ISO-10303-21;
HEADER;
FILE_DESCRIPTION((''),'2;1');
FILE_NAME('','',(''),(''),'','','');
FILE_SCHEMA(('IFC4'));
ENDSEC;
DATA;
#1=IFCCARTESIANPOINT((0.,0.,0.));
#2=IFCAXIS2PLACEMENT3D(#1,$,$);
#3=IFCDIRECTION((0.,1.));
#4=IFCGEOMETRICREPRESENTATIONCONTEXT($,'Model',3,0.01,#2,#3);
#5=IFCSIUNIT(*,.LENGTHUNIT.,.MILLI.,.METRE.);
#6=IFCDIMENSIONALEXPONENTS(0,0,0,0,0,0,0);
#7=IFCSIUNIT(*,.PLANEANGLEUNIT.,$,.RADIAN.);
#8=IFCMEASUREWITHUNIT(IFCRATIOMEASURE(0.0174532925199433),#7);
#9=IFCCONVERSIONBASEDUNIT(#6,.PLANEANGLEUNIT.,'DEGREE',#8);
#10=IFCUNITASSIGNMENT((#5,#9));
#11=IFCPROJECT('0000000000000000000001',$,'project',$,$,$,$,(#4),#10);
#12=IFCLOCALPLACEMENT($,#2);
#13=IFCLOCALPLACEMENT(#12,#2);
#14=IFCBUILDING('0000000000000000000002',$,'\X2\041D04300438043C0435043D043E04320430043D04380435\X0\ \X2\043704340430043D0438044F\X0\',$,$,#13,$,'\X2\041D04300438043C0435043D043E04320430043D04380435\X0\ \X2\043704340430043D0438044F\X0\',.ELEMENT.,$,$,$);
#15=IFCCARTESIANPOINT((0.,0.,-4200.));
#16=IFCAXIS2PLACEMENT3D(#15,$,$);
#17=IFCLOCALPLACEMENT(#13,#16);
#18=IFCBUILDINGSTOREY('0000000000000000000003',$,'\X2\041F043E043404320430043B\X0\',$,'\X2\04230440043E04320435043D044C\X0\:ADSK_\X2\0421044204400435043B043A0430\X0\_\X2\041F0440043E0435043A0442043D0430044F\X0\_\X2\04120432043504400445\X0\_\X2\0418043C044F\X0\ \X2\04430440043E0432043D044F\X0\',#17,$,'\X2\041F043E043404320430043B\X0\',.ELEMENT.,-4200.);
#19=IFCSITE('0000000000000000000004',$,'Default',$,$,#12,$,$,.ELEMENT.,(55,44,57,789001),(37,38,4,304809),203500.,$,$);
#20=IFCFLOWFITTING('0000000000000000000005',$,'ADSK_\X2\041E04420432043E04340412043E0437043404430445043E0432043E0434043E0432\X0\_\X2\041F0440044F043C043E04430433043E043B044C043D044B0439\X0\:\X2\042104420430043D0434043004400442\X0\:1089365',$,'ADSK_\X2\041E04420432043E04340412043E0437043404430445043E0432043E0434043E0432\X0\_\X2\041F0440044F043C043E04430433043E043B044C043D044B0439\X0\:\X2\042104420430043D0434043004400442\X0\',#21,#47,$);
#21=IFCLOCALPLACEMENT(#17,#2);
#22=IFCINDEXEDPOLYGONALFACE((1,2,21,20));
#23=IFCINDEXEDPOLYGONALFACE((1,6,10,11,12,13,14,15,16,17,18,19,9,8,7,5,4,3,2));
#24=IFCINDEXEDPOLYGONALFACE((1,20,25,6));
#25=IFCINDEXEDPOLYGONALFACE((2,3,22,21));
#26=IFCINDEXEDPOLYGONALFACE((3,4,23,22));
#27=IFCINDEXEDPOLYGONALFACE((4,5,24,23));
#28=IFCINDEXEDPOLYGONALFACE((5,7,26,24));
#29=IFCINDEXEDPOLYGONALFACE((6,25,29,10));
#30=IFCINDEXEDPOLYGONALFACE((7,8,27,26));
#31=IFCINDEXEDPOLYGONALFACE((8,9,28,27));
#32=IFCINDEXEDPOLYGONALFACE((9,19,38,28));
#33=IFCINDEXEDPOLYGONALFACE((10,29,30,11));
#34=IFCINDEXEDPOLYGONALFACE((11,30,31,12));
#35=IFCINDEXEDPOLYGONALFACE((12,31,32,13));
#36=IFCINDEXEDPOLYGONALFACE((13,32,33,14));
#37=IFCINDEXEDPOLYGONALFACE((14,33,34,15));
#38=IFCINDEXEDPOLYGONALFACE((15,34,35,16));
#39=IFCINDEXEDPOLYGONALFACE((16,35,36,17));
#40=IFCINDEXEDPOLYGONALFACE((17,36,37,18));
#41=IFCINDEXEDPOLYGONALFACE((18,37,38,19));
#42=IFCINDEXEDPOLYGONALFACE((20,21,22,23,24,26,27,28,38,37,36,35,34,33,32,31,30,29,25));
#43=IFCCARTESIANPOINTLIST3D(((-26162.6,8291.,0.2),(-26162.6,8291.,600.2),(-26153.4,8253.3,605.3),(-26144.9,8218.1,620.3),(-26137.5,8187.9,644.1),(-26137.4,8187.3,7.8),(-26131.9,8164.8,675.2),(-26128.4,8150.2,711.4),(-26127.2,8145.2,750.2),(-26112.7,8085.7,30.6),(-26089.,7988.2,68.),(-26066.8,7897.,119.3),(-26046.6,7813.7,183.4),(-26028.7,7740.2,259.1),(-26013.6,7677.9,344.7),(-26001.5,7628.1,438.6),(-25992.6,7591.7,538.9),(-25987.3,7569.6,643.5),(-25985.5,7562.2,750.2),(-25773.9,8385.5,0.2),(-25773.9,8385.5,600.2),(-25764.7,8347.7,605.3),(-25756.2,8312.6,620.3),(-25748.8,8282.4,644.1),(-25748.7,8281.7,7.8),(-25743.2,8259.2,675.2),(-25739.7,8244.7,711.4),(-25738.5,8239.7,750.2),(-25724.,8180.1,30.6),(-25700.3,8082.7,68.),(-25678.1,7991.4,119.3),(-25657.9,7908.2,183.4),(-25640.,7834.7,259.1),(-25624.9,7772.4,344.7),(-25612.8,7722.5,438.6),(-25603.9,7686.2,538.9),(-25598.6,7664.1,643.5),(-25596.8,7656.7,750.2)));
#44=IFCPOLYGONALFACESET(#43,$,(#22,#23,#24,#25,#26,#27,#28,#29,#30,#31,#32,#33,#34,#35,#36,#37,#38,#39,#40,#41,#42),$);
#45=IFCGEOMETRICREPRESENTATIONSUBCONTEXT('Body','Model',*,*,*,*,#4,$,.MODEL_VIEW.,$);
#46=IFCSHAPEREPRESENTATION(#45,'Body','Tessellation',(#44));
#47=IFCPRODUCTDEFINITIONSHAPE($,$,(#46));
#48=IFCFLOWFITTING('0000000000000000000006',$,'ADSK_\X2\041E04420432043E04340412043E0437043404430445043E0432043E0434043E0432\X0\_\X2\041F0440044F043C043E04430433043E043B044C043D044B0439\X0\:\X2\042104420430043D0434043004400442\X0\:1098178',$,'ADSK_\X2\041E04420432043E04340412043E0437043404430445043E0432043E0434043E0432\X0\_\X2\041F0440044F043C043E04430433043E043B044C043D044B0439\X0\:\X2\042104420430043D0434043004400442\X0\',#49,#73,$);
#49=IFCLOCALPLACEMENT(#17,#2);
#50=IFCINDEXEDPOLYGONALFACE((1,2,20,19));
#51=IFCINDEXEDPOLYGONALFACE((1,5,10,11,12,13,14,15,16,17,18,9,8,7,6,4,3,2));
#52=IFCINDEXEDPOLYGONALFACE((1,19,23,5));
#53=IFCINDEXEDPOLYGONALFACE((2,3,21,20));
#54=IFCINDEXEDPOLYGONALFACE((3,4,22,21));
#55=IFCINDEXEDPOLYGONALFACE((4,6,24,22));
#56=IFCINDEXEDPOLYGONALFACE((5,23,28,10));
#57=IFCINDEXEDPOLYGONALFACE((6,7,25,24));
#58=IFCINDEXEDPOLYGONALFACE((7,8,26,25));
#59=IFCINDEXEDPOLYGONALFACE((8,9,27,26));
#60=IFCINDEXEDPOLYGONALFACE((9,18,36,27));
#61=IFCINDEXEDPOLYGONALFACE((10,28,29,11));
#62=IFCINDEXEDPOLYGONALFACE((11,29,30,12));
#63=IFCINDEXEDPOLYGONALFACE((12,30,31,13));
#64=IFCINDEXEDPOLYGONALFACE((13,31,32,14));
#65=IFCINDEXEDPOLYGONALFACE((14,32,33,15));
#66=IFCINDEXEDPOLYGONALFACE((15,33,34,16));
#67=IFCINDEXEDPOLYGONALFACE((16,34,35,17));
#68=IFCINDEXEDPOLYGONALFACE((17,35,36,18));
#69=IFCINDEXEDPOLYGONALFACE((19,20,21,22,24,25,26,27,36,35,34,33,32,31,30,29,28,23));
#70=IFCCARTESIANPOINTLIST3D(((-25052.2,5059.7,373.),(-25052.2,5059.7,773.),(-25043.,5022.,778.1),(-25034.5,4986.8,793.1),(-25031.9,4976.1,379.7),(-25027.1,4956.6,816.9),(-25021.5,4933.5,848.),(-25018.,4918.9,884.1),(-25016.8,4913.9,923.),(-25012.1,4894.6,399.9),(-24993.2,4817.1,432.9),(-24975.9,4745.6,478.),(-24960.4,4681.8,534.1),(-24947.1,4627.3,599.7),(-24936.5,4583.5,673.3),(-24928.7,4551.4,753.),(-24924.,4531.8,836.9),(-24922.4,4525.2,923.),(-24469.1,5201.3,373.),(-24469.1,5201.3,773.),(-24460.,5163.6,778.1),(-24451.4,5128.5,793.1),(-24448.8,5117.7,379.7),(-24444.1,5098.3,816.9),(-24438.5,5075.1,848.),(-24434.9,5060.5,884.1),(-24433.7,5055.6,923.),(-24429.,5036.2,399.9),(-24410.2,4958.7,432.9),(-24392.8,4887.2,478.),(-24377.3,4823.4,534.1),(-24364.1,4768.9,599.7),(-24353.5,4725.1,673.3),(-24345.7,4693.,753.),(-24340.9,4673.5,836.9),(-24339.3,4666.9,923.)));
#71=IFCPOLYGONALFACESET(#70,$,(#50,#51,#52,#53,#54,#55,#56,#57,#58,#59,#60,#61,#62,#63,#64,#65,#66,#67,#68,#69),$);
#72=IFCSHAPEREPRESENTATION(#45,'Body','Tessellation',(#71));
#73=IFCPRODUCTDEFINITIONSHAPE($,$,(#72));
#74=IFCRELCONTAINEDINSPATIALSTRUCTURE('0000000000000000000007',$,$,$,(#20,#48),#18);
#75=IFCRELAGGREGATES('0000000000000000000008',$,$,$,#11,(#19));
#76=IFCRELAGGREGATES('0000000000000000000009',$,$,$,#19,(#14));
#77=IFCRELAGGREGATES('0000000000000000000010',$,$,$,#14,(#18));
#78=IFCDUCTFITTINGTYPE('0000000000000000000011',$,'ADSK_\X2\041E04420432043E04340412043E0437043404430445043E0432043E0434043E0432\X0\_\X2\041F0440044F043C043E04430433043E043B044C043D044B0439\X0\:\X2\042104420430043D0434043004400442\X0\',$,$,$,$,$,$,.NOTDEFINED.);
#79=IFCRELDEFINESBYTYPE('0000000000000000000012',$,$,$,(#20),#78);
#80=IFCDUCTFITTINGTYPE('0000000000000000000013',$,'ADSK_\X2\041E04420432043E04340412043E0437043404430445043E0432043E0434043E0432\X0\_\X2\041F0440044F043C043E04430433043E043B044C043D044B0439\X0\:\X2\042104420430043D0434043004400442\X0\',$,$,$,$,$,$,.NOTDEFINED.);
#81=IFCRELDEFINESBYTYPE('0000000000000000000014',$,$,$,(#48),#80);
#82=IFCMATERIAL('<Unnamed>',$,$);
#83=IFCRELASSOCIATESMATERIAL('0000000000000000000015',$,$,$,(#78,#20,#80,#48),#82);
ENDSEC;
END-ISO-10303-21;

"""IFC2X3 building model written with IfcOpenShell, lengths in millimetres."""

from ifc_helpers import new_model, entity, si_unit, converted_unit, direction, frame, frame_2d, origin, place, context, subcontext, project, spatial, polyline, circle_curve, parameter, trimmed, segment, composite_curve, outline, extrude, source, transform, mapped, material, type_object, type_shapes, element, save


model = new_model("IFC2X3")

# Units and contexts
model_context = context("Model", 3, precision=0.01, world=origin(), true_north=direction((0.0, 1.0)))
body_context = subcontext(model_context, "Body", "Model", "MODEL_VIEW")
ifc_project = project(units=[si_unit("LENGTHUNIT", "METRE", prefix="MILLI"), converted_unit("PLANEANGLEUNIT", "DEGREE", entity("IfcRatioMeasure", 0.0174532925199433), si_unit("PLANEANGLEUNIT", "RADIAN"), dimensions=[0, 0, 0, 0, 0, 0, 0])], contexts=[model_context])

# Site, building, storey
site_placement = place(None, origin())
site = spatial("IfcSite", under=ifc_project, at=site_placement, Name="Default", CompositionType="ELEMENT", RefLatitude=(55, 44, 57, 789001), RefLongitude=(37, 38, 4, 304809), RefElevation=203500.0)
building_placement = place(site_placement, origin())
building = spatial("IfcBuilding", under=site, at=building_placement, Name="Наименование здания", LongName="Наименование здания", CompositionType="ELEMENT")
storey_placement = place(building_placement, frame((0.0, 0.0, -4200.0)))
storey = spatial("IfcBuildingStorey", under=building, at=storey_placement, Name="Подвал", ObjectType="Уровень:ADSK_Стрелка_Проектная_Вверх_Имя уровня", LongName="Подвал", CompositionType="ELEMENT", Elevation=-4200.0)

# Shared definitions
ifc_material_1 = material(Name="<Unnamed>")

# Flow fittings
duct_fitting_type_1 = type_object("IfcDuctFittingType", Name="ADSK_ОтводВоздуховодов_Прямоугольный:Стандарт", PredefinedType="NOTDEFINED", material=ifc_material_1)
shared_shape_1 = source(origin(), body_context, "Body", "SweptSolid", [
    extrude(outline(composite_curve([segment(polyline([(-525.0, -225.0), (75.0, -225.0)]), True, "CONTINUOUS"), segment(trimmed(circle_curve(frame_2d((225.0, -225.0), x_axis=(0.0, 1.0)), 150.0), [parameter(0.0)], [parameter(90.0)], True, "PARAMETER"), False, "CONTINUOUS"), segment(polyline([(225.0, -75.0), (225.0, 525.0)]), True, "CONTINUOUS"), segment(trimmed(circle_curve(frame_2d((225.0, -225.0), x_axis=(0.0, 1.0)), 750.0), [parameter(0.0)], [parameter(90.0)], True, "PARAMETER"), True, "CONTINUOUS")], self_intersect=False)), frame((-225.0, 225.0, -200.0), z_axis=(0.0, 0.0, 1.0), x_axis=(-1.0, 0.0, 0.0)), (0.0, 0.0, 1.0), 400.0),
])
type_shapes(duct_fitting_type_1, [shared_shape_1])
for number, where, z_axis, x_axis, name in (
    (1, (-25862.0, 7900.9, 300.2), (0.971714, 0.23616, 0.0), (0.0, 0.0, -1.0), "ADSK_ОтводВоздуховодов_Прямоугольный:Стандарт:1089365"),
):
    element("IfcFlowFitting", number, at=place(storey_placement, frame(where, z_axis=z_axis, x_axis=x_axis)), inside=storey, type_object=duct_fitting_type_1, material=ifc_material_1, Name=name, ObjectType="ADSK_ОтводВоздуховодов_Прямоугольный:Стандарт", context=body_context, shape_type="MappedRepresentation", body=[
        mapped(shared_shape_1, transform((0.0, 0.0, 0.0), scale=1.0)),
    ])
duct_fitting_type_2 = type_object("IfcDuctFittingType", Name="ADSK_ОтводВоздуховодов_Прямоугольный:Стандарт", PredefinedType="NOTDEFINED", material=ifc_material_1)
shared_shape_2 = source(origin(), body_context, "Body", "SweptSolid", [
    extrude(outline(composite_curve([segment(polyline([(-375.0, -175.0), (25.0, -175.0)]), True, "CONTINUOUS"), segment(trimmed(circle_curve(frame_2d((175.0, -175.0), x_axis=(0.0, 1.0)), 150.0), [parameter(0.0)], [parameter(90.0)], True, "PARAMETER"), False, "CONTINUOUS"), segment(polyline([(175.0, -25.0), (175.0, 375.0)]), True, "CONTINUOUS"), segment(trimmed(circle_curve(frame_2d((175.0, -175.0), x_axis=(0.0, 1.0)), 550.0), [parameter(0.0)], [parameter(90.0)], True, "PARAMETER"), True, "CONTINUOUS")], self_intersect=False)), frame((-175.0, 175.0, -300.0), z_axis=(0.0, 0.0, 1.0), x_axis=(-1.0, 0.0, 0.0)), (0.0, 0.0, 1.0), 600.0),
])
type_shapes(duct_fitting_type_2, [shared_shape_2])
flow_fitting_1_placement = place(storey_placement, frame((-24678.0, 4790.4, 573.0), z_axis=(-0.971743, -0.23604, 0.0), x_axis=(0.23604, -0.971743, 0.0)))
element("IfcFlowFitting", 2, at=flow_fitting_1_placement, inside=storey, type_object=duct_fitting_type_2, material=ifc_material_1, Name="ADSK_ОтводВоздуховодов_Прямоугольный:Стандарт:1098178", ObjectType="ADSK_ОтводВоздуховодов_Прямоугольный:Стандарт", context=body_context, shape_type="MappedRepresentation", body=[
    mapped(shared_shape_2, transform((0.0, 0.0, 0.0), scale=1.0)),
])

save(model, "model.ifc")
